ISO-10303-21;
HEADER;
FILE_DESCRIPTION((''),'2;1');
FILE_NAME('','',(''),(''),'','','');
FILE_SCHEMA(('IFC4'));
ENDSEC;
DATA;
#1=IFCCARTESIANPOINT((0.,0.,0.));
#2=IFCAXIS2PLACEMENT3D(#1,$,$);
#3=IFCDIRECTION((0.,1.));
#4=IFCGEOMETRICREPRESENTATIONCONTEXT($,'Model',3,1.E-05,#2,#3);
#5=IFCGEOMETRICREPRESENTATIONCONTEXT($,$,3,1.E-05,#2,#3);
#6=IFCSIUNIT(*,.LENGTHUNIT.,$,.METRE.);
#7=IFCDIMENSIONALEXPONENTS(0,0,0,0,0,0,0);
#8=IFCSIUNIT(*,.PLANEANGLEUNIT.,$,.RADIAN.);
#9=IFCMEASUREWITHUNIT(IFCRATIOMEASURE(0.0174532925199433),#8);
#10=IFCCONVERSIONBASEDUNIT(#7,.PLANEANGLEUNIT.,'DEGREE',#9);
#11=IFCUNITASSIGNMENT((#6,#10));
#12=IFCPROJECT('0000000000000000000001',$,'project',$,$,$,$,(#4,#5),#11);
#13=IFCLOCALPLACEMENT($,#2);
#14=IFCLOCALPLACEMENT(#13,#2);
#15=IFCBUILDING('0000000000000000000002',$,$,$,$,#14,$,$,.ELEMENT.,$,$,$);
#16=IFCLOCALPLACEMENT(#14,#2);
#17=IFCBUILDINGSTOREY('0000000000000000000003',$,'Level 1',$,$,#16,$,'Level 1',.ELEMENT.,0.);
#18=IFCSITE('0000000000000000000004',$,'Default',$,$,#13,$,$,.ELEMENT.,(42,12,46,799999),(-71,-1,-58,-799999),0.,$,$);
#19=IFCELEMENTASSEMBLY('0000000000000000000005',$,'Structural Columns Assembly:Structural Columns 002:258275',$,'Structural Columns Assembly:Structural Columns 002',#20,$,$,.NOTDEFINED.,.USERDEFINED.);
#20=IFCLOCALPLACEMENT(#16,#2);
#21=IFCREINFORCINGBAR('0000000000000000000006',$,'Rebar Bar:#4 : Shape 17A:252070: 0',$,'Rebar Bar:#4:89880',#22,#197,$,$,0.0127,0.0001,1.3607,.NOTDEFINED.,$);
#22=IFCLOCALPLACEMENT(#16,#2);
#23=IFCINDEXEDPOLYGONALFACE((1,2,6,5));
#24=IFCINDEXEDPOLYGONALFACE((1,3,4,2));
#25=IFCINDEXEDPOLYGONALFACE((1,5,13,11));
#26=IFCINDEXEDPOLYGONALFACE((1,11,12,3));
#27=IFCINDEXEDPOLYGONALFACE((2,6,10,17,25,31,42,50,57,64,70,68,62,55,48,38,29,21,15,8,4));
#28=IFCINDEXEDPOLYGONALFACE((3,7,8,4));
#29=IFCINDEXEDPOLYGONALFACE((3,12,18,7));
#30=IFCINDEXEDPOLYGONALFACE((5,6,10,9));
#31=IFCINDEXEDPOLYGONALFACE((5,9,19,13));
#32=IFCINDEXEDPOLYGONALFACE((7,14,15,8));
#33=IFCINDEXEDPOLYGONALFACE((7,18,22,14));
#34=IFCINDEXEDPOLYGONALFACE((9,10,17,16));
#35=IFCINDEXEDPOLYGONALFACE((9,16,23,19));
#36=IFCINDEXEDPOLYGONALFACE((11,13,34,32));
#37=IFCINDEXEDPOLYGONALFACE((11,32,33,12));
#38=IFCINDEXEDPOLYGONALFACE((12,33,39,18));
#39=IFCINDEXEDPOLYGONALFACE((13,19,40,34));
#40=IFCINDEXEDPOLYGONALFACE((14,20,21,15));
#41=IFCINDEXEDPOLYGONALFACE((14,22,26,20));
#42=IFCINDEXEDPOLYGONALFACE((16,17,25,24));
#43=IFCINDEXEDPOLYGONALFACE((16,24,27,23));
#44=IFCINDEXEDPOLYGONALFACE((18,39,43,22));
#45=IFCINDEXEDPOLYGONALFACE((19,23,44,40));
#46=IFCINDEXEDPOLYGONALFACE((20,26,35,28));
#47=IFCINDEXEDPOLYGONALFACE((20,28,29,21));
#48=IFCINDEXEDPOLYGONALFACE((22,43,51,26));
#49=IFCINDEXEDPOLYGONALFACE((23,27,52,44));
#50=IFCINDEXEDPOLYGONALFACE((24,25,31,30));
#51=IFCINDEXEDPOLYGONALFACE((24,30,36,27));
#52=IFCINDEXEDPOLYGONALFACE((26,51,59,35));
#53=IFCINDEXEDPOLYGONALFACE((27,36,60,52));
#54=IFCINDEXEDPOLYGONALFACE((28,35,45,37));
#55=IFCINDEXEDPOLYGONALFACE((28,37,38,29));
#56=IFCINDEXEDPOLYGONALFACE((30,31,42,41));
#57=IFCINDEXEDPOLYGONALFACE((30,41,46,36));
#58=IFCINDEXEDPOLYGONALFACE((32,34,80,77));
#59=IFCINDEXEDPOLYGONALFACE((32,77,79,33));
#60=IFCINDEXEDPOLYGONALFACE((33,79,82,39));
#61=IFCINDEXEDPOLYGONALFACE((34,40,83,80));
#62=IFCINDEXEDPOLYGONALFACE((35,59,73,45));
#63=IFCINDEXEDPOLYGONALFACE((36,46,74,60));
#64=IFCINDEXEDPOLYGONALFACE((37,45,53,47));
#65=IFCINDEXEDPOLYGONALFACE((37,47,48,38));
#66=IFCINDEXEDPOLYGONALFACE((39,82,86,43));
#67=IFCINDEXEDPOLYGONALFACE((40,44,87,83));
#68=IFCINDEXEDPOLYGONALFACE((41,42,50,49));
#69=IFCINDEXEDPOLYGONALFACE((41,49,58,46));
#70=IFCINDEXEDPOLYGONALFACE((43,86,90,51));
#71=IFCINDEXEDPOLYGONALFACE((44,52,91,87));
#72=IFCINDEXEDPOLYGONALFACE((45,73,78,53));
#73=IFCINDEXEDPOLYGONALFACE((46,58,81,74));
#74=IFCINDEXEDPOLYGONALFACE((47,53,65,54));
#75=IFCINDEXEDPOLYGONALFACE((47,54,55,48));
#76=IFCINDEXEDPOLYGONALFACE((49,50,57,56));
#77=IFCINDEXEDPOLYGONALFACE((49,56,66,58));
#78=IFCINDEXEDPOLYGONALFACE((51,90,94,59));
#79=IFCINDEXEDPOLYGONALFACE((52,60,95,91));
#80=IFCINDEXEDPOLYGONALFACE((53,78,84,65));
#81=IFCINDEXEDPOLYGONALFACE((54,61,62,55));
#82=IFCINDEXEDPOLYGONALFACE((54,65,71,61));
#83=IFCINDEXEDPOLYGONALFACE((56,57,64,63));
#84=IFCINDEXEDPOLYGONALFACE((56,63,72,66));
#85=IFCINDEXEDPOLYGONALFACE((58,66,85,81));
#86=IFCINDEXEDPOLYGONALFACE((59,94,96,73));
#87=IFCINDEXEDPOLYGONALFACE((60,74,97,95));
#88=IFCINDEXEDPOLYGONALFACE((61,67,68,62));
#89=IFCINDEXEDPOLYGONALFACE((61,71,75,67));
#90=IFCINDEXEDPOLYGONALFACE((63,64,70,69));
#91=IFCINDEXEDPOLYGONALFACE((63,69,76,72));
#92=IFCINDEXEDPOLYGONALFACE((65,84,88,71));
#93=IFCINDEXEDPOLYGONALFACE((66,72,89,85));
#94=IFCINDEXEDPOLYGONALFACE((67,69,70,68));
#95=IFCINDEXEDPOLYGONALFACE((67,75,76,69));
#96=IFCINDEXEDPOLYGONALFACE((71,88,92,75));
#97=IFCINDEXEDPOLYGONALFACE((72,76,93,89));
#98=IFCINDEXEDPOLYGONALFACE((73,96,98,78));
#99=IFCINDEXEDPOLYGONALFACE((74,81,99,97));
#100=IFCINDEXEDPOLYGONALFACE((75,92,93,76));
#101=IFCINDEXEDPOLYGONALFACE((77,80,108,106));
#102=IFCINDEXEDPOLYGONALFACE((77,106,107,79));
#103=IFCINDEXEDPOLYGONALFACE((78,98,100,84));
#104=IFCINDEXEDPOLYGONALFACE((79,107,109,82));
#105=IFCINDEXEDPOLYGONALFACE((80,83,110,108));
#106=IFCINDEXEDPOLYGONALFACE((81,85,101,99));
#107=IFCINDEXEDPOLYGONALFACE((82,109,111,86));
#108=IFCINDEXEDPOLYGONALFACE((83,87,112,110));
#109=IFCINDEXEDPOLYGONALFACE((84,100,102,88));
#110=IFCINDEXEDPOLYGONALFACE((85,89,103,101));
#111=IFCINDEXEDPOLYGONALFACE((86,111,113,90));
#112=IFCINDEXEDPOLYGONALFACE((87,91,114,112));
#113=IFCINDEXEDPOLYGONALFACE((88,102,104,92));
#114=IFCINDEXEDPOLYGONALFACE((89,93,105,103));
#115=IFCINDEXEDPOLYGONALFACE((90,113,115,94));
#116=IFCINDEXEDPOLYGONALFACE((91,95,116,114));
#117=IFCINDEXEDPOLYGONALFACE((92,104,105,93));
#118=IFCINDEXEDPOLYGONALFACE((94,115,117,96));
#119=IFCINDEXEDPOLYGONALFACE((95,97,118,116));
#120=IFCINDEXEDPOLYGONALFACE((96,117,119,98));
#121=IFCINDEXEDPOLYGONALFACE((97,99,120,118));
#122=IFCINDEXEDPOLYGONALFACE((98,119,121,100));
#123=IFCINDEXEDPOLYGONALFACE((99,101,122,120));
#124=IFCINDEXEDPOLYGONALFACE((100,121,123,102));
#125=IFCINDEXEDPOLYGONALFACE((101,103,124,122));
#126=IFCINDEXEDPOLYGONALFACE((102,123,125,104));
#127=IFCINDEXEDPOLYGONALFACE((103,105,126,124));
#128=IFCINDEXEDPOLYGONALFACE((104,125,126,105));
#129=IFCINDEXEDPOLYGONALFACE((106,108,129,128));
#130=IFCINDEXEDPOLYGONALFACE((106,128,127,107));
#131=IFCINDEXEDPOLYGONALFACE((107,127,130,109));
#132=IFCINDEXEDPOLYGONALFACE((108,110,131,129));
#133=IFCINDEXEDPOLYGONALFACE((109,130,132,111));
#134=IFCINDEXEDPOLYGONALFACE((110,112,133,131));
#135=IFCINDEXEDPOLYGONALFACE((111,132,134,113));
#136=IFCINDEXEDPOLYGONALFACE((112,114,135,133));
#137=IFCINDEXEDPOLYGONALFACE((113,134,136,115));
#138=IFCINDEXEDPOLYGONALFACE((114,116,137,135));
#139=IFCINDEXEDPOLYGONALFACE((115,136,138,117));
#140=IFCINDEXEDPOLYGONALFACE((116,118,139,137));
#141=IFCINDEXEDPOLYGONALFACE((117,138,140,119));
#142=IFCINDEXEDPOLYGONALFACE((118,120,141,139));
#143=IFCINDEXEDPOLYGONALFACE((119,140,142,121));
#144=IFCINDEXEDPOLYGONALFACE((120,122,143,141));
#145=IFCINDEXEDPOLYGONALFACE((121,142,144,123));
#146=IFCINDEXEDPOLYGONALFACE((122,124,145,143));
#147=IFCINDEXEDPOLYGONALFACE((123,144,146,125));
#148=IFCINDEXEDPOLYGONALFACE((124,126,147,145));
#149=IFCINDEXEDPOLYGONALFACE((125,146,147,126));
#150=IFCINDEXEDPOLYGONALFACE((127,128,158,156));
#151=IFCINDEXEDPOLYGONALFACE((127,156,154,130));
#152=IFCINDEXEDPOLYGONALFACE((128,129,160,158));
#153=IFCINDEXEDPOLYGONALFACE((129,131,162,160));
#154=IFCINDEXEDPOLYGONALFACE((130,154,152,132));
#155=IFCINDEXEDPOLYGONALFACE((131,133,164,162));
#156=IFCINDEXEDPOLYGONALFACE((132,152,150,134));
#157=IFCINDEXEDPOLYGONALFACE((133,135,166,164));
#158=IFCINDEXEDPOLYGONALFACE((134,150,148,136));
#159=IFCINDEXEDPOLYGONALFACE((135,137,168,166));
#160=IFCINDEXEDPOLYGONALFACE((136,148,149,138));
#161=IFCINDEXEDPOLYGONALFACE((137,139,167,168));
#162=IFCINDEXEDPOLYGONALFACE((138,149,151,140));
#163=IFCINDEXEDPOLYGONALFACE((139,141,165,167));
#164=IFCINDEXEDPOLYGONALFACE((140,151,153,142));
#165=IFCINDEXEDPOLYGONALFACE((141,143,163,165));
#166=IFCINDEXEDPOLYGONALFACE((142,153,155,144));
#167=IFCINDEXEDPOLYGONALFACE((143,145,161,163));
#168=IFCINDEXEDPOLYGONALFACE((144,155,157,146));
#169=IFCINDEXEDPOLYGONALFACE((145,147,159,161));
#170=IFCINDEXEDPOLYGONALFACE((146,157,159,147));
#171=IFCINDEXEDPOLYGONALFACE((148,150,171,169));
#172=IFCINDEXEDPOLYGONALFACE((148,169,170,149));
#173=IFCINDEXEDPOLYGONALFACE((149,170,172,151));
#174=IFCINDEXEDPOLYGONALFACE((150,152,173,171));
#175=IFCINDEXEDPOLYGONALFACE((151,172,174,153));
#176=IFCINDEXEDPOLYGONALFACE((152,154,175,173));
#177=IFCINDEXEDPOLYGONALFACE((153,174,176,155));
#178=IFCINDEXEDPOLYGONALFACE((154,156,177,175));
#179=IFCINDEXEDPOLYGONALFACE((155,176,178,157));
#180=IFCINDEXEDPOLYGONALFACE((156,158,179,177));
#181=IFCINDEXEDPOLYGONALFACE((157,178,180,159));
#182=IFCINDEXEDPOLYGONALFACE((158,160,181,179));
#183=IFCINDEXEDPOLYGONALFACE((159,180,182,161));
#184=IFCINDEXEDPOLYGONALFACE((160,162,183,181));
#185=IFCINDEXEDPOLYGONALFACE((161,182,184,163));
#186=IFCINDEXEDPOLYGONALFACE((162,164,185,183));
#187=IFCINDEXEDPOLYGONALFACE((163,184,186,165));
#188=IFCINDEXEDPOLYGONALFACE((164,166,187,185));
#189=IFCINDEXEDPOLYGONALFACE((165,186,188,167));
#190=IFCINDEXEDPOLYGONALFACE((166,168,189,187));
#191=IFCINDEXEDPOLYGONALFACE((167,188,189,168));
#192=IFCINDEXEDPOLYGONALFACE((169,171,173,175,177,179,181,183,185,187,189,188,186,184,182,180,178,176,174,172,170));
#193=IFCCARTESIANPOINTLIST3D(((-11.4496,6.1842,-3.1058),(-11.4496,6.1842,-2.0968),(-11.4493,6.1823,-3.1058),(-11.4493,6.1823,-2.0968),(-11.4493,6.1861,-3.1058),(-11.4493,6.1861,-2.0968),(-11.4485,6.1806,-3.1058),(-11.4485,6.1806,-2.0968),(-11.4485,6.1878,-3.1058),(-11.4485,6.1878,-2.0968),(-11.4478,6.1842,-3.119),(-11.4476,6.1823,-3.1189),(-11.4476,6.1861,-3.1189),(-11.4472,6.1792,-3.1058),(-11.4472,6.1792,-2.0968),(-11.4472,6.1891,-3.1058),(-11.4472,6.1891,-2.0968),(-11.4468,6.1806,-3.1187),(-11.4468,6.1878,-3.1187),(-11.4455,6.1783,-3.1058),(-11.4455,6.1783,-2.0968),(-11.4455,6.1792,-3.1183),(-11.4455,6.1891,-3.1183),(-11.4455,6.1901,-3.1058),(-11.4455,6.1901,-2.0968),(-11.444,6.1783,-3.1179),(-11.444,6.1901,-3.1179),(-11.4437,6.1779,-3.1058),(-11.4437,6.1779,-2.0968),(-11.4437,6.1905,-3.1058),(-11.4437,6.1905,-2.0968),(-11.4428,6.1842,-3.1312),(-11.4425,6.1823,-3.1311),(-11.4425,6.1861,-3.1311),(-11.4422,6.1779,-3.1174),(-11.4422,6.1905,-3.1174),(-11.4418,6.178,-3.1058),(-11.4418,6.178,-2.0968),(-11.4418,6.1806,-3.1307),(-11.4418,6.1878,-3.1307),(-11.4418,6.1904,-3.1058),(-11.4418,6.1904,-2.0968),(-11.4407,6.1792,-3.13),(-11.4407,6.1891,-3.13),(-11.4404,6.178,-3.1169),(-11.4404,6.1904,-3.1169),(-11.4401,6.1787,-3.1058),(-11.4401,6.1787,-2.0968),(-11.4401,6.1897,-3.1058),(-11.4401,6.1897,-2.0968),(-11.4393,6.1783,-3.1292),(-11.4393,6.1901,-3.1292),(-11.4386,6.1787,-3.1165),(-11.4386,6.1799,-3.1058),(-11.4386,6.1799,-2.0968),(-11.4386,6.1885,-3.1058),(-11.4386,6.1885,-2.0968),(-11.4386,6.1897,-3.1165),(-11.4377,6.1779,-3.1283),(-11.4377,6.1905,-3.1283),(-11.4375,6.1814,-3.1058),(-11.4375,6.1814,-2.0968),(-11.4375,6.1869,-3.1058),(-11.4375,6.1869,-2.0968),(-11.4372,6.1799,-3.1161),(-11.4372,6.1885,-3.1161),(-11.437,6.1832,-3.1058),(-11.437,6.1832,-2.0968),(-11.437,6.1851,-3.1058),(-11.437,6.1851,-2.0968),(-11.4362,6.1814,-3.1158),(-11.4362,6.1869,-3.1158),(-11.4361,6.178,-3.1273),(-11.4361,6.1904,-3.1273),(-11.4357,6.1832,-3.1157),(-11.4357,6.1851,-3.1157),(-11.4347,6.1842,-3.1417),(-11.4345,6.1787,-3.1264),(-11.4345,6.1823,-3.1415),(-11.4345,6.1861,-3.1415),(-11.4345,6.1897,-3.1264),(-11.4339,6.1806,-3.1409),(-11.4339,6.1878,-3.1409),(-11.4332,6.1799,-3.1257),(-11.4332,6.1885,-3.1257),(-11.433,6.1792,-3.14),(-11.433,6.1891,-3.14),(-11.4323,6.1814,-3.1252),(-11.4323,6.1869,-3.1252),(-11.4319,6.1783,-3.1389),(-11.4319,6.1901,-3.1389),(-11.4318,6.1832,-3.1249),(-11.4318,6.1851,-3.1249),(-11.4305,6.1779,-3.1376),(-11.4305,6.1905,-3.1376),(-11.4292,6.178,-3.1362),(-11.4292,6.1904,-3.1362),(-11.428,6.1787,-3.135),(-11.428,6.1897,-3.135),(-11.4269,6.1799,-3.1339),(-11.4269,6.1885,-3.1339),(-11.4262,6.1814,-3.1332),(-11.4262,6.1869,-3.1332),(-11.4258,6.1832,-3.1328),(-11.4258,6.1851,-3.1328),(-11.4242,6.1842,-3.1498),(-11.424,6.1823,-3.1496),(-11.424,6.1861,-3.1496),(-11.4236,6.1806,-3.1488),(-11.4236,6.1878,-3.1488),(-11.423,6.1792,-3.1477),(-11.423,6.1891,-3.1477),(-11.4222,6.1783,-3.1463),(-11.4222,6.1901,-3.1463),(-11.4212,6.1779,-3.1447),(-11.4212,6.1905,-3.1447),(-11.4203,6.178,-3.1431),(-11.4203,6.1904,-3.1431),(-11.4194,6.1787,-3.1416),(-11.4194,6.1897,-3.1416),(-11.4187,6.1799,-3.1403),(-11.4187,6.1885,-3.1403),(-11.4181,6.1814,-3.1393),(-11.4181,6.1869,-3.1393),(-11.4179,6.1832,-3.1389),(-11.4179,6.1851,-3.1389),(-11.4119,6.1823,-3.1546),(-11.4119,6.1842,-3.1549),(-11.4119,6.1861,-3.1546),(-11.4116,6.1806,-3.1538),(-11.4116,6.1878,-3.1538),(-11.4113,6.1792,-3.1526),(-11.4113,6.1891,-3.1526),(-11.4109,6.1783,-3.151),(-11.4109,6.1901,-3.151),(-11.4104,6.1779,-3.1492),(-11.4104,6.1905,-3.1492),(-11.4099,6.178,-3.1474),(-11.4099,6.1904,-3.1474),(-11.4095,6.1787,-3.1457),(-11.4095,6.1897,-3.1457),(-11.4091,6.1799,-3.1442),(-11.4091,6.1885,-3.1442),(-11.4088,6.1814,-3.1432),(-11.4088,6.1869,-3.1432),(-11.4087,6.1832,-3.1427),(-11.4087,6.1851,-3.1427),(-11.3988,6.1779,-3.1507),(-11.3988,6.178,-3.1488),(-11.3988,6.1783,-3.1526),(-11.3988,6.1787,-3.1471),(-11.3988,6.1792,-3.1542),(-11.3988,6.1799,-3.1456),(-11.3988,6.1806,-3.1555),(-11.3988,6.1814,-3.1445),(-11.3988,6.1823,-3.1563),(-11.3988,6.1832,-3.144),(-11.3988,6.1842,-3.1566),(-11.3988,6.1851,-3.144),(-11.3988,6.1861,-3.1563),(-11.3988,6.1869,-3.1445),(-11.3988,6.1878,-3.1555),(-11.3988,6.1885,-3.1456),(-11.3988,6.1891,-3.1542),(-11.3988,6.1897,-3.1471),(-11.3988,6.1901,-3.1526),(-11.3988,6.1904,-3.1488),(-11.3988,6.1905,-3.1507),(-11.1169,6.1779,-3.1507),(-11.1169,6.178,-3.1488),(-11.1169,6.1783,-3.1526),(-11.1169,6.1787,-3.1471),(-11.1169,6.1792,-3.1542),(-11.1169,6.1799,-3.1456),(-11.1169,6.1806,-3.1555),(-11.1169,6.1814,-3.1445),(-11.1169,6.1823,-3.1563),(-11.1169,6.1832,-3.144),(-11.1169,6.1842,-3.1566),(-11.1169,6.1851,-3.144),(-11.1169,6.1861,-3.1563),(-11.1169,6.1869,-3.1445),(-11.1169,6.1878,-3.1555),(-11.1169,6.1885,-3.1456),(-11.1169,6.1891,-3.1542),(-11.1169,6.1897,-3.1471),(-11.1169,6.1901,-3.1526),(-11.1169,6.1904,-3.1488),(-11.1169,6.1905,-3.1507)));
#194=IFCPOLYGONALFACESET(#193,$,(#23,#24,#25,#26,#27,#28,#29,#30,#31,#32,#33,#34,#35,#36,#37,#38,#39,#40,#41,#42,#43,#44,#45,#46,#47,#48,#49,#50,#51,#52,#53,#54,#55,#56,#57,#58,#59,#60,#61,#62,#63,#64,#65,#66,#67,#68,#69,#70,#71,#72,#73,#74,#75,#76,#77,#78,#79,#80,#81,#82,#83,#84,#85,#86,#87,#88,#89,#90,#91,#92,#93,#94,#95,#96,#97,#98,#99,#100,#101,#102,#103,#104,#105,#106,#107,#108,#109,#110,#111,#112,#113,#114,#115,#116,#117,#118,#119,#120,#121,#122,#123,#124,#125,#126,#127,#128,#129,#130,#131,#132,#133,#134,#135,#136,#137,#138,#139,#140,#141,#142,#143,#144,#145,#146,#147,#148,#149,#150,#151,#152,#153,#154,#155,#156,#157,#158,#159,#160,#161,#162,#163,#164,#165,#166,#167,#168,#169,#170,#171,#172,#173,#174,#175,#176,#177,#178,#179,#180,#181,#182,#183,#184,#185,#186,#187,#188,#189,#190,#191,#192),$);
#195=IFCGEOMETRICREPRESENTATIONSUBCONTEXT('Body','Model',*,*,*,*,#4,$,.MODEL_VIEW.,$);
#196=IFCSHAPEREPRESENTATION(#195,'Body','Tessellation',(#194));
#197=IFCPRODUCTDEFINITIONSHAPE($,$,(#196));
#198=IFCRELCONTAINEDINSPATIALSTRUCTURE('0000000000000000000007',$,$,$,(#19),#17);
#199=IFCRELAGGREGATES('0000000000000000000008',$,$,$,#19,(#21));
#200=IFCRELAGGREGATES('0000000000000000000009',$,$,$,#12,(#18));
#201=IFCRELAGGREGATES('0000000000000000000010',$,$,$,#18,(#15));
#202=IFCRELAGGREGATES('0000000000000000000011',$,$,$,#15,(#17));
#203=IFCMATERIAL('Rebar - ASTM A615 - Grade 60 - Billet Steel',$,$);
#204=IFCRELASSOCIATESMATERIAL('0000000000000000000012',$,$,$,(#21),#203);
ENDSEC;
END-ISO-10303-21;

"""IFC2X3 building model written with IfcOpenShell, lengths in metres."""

from ifc_helpers import new_model, entity, si_unit, converted_unit, direction, origin, place, context, subcontext, project, spatial, material, element, aggregate, save


model = new_model("IFC2X3")

# Units and contexts
model_context = context("Model", 3, precision=1e-05, world=origin(), true_north=direction((0.0, 1.0)))
context_of_model = context(None, 3, precision=1e-05, world=origin(), true_north=direction((0.0, 1.0)))
body_context = subcontext(model_context, "Body", "Model", "MODEL_VIEW")
ifc_project = project(units=[si_unit("LENGTHUNIT", "METRE"), converted_unit("PLANEANGLEUNIT", "DEGREE", entity("IfcRatioMeasure", 0.0174532925199433), si_unit("PLANEANGLEUNIT", "RADIAN"), dimensions=[0, 0, 0, 0, 0, 0, 0])], contexts=[model_context, context_of_model])

# Site, building, storey
site_placement = place(None, origin())
site = spatial("IfcSite", under=ifc_project, at=site_placement, Name="Default", CompositionType="ELEMENT", RefLatitude=(42, 12, 46, 799999), RefLongitude=(-71, -1, -58, -799999), RefElevation=0.0)
building_placement = place(site_placement, origin())
building = spatial("IfcBuilding", under=site, at=building_placement, CompositionType="ELEMENT")
storey_placement = place(building_placement, origin())
storey = spatial("IfcBuildingStorey", under=building, at=storey_placement, Name="Level 1", LongName="Level 1", CompositionType="ELEMENT", Elevation=0.0)

# Element assembly, reinforcing bar
assembly_1_placement = place(storey_placement, origin())
assembly_1 = element("IfcElementAssembly", 1, at=assembly_1_placement, inside=storey, Name="Structural Columns Assembly:Structural Columns 002:258275", ObjectType="Structural Columns Assembly:Structural Columns 002", AssemblyPlace="NOTDEFINED", PredefinedType="USERDEFINED")
ifc_material_1 = material(Name="Rebar - ASTM A615 - Grade 60 - Billet Steel")
reinforcing_bar_1_placement = place(assembly_1_placement, origin())
reinforcing_bar_1 = element("IfcReinforcingBar", 2, at=reinforcing_bar_1_placement, material=ifc_material_1, Name="Rebar Bar:#4 : Shape 17A:252070: 0", ObjectType="Rebar Bar:#4:89880", BarLength=1.3607, BarRole="NOTDEFINED", CrossSectionArea=0.0001, NominalDiameter=0.0127, context=body_context, shape_type="AdvancedSweptSolid", body=[
    entity("IfcSweptDiskSolid", entity("IfcCompositeCurve", [entity("IfcCompositeCurveSegment", "CONTINUOUS", True, entity("IfcPolyline", [entity("IfcCartesianPoint", [-11.4432, 6.1842, -2.0968]), entity("IfcCartesianPoint", [-11.4432, 6.1842, -3.1058])])), entity("IfcCompositeCurveSegment", "CONTINUOUS", True, entity("IfcTrimmedCurve", entity("IfcCircle", entity("IfcAxis2Placement3D", entity("IfcCartesianPoint", [-11.3988, 6.1842, -3.1058]), entity("IfcDirection", [0.0, -1.0, 0.0]), entity("IfcDirection", [0.0, 0.0, -1.0])), 0.0445), [entity("IfcParameterValue", 270.0)], [entity("IfcParameterValue", 360.0)], True, "PARAMETER")), entity("IfcCompositeCurveSegment", "CONTINUOUS", True, entity("IfcPolyline", [entity("IfcCartesianPoint", [-11.3988, 6.1842, -3.1503]), entity("IfcCartesianPoint", [-11.1169, 6.1842, -3.1503])]))], False), 0.0063, None, 0.0, 92.0),
])
aggregate(assembly_1, [reinforcing_bar_1])

save(model, "model.ifc")
